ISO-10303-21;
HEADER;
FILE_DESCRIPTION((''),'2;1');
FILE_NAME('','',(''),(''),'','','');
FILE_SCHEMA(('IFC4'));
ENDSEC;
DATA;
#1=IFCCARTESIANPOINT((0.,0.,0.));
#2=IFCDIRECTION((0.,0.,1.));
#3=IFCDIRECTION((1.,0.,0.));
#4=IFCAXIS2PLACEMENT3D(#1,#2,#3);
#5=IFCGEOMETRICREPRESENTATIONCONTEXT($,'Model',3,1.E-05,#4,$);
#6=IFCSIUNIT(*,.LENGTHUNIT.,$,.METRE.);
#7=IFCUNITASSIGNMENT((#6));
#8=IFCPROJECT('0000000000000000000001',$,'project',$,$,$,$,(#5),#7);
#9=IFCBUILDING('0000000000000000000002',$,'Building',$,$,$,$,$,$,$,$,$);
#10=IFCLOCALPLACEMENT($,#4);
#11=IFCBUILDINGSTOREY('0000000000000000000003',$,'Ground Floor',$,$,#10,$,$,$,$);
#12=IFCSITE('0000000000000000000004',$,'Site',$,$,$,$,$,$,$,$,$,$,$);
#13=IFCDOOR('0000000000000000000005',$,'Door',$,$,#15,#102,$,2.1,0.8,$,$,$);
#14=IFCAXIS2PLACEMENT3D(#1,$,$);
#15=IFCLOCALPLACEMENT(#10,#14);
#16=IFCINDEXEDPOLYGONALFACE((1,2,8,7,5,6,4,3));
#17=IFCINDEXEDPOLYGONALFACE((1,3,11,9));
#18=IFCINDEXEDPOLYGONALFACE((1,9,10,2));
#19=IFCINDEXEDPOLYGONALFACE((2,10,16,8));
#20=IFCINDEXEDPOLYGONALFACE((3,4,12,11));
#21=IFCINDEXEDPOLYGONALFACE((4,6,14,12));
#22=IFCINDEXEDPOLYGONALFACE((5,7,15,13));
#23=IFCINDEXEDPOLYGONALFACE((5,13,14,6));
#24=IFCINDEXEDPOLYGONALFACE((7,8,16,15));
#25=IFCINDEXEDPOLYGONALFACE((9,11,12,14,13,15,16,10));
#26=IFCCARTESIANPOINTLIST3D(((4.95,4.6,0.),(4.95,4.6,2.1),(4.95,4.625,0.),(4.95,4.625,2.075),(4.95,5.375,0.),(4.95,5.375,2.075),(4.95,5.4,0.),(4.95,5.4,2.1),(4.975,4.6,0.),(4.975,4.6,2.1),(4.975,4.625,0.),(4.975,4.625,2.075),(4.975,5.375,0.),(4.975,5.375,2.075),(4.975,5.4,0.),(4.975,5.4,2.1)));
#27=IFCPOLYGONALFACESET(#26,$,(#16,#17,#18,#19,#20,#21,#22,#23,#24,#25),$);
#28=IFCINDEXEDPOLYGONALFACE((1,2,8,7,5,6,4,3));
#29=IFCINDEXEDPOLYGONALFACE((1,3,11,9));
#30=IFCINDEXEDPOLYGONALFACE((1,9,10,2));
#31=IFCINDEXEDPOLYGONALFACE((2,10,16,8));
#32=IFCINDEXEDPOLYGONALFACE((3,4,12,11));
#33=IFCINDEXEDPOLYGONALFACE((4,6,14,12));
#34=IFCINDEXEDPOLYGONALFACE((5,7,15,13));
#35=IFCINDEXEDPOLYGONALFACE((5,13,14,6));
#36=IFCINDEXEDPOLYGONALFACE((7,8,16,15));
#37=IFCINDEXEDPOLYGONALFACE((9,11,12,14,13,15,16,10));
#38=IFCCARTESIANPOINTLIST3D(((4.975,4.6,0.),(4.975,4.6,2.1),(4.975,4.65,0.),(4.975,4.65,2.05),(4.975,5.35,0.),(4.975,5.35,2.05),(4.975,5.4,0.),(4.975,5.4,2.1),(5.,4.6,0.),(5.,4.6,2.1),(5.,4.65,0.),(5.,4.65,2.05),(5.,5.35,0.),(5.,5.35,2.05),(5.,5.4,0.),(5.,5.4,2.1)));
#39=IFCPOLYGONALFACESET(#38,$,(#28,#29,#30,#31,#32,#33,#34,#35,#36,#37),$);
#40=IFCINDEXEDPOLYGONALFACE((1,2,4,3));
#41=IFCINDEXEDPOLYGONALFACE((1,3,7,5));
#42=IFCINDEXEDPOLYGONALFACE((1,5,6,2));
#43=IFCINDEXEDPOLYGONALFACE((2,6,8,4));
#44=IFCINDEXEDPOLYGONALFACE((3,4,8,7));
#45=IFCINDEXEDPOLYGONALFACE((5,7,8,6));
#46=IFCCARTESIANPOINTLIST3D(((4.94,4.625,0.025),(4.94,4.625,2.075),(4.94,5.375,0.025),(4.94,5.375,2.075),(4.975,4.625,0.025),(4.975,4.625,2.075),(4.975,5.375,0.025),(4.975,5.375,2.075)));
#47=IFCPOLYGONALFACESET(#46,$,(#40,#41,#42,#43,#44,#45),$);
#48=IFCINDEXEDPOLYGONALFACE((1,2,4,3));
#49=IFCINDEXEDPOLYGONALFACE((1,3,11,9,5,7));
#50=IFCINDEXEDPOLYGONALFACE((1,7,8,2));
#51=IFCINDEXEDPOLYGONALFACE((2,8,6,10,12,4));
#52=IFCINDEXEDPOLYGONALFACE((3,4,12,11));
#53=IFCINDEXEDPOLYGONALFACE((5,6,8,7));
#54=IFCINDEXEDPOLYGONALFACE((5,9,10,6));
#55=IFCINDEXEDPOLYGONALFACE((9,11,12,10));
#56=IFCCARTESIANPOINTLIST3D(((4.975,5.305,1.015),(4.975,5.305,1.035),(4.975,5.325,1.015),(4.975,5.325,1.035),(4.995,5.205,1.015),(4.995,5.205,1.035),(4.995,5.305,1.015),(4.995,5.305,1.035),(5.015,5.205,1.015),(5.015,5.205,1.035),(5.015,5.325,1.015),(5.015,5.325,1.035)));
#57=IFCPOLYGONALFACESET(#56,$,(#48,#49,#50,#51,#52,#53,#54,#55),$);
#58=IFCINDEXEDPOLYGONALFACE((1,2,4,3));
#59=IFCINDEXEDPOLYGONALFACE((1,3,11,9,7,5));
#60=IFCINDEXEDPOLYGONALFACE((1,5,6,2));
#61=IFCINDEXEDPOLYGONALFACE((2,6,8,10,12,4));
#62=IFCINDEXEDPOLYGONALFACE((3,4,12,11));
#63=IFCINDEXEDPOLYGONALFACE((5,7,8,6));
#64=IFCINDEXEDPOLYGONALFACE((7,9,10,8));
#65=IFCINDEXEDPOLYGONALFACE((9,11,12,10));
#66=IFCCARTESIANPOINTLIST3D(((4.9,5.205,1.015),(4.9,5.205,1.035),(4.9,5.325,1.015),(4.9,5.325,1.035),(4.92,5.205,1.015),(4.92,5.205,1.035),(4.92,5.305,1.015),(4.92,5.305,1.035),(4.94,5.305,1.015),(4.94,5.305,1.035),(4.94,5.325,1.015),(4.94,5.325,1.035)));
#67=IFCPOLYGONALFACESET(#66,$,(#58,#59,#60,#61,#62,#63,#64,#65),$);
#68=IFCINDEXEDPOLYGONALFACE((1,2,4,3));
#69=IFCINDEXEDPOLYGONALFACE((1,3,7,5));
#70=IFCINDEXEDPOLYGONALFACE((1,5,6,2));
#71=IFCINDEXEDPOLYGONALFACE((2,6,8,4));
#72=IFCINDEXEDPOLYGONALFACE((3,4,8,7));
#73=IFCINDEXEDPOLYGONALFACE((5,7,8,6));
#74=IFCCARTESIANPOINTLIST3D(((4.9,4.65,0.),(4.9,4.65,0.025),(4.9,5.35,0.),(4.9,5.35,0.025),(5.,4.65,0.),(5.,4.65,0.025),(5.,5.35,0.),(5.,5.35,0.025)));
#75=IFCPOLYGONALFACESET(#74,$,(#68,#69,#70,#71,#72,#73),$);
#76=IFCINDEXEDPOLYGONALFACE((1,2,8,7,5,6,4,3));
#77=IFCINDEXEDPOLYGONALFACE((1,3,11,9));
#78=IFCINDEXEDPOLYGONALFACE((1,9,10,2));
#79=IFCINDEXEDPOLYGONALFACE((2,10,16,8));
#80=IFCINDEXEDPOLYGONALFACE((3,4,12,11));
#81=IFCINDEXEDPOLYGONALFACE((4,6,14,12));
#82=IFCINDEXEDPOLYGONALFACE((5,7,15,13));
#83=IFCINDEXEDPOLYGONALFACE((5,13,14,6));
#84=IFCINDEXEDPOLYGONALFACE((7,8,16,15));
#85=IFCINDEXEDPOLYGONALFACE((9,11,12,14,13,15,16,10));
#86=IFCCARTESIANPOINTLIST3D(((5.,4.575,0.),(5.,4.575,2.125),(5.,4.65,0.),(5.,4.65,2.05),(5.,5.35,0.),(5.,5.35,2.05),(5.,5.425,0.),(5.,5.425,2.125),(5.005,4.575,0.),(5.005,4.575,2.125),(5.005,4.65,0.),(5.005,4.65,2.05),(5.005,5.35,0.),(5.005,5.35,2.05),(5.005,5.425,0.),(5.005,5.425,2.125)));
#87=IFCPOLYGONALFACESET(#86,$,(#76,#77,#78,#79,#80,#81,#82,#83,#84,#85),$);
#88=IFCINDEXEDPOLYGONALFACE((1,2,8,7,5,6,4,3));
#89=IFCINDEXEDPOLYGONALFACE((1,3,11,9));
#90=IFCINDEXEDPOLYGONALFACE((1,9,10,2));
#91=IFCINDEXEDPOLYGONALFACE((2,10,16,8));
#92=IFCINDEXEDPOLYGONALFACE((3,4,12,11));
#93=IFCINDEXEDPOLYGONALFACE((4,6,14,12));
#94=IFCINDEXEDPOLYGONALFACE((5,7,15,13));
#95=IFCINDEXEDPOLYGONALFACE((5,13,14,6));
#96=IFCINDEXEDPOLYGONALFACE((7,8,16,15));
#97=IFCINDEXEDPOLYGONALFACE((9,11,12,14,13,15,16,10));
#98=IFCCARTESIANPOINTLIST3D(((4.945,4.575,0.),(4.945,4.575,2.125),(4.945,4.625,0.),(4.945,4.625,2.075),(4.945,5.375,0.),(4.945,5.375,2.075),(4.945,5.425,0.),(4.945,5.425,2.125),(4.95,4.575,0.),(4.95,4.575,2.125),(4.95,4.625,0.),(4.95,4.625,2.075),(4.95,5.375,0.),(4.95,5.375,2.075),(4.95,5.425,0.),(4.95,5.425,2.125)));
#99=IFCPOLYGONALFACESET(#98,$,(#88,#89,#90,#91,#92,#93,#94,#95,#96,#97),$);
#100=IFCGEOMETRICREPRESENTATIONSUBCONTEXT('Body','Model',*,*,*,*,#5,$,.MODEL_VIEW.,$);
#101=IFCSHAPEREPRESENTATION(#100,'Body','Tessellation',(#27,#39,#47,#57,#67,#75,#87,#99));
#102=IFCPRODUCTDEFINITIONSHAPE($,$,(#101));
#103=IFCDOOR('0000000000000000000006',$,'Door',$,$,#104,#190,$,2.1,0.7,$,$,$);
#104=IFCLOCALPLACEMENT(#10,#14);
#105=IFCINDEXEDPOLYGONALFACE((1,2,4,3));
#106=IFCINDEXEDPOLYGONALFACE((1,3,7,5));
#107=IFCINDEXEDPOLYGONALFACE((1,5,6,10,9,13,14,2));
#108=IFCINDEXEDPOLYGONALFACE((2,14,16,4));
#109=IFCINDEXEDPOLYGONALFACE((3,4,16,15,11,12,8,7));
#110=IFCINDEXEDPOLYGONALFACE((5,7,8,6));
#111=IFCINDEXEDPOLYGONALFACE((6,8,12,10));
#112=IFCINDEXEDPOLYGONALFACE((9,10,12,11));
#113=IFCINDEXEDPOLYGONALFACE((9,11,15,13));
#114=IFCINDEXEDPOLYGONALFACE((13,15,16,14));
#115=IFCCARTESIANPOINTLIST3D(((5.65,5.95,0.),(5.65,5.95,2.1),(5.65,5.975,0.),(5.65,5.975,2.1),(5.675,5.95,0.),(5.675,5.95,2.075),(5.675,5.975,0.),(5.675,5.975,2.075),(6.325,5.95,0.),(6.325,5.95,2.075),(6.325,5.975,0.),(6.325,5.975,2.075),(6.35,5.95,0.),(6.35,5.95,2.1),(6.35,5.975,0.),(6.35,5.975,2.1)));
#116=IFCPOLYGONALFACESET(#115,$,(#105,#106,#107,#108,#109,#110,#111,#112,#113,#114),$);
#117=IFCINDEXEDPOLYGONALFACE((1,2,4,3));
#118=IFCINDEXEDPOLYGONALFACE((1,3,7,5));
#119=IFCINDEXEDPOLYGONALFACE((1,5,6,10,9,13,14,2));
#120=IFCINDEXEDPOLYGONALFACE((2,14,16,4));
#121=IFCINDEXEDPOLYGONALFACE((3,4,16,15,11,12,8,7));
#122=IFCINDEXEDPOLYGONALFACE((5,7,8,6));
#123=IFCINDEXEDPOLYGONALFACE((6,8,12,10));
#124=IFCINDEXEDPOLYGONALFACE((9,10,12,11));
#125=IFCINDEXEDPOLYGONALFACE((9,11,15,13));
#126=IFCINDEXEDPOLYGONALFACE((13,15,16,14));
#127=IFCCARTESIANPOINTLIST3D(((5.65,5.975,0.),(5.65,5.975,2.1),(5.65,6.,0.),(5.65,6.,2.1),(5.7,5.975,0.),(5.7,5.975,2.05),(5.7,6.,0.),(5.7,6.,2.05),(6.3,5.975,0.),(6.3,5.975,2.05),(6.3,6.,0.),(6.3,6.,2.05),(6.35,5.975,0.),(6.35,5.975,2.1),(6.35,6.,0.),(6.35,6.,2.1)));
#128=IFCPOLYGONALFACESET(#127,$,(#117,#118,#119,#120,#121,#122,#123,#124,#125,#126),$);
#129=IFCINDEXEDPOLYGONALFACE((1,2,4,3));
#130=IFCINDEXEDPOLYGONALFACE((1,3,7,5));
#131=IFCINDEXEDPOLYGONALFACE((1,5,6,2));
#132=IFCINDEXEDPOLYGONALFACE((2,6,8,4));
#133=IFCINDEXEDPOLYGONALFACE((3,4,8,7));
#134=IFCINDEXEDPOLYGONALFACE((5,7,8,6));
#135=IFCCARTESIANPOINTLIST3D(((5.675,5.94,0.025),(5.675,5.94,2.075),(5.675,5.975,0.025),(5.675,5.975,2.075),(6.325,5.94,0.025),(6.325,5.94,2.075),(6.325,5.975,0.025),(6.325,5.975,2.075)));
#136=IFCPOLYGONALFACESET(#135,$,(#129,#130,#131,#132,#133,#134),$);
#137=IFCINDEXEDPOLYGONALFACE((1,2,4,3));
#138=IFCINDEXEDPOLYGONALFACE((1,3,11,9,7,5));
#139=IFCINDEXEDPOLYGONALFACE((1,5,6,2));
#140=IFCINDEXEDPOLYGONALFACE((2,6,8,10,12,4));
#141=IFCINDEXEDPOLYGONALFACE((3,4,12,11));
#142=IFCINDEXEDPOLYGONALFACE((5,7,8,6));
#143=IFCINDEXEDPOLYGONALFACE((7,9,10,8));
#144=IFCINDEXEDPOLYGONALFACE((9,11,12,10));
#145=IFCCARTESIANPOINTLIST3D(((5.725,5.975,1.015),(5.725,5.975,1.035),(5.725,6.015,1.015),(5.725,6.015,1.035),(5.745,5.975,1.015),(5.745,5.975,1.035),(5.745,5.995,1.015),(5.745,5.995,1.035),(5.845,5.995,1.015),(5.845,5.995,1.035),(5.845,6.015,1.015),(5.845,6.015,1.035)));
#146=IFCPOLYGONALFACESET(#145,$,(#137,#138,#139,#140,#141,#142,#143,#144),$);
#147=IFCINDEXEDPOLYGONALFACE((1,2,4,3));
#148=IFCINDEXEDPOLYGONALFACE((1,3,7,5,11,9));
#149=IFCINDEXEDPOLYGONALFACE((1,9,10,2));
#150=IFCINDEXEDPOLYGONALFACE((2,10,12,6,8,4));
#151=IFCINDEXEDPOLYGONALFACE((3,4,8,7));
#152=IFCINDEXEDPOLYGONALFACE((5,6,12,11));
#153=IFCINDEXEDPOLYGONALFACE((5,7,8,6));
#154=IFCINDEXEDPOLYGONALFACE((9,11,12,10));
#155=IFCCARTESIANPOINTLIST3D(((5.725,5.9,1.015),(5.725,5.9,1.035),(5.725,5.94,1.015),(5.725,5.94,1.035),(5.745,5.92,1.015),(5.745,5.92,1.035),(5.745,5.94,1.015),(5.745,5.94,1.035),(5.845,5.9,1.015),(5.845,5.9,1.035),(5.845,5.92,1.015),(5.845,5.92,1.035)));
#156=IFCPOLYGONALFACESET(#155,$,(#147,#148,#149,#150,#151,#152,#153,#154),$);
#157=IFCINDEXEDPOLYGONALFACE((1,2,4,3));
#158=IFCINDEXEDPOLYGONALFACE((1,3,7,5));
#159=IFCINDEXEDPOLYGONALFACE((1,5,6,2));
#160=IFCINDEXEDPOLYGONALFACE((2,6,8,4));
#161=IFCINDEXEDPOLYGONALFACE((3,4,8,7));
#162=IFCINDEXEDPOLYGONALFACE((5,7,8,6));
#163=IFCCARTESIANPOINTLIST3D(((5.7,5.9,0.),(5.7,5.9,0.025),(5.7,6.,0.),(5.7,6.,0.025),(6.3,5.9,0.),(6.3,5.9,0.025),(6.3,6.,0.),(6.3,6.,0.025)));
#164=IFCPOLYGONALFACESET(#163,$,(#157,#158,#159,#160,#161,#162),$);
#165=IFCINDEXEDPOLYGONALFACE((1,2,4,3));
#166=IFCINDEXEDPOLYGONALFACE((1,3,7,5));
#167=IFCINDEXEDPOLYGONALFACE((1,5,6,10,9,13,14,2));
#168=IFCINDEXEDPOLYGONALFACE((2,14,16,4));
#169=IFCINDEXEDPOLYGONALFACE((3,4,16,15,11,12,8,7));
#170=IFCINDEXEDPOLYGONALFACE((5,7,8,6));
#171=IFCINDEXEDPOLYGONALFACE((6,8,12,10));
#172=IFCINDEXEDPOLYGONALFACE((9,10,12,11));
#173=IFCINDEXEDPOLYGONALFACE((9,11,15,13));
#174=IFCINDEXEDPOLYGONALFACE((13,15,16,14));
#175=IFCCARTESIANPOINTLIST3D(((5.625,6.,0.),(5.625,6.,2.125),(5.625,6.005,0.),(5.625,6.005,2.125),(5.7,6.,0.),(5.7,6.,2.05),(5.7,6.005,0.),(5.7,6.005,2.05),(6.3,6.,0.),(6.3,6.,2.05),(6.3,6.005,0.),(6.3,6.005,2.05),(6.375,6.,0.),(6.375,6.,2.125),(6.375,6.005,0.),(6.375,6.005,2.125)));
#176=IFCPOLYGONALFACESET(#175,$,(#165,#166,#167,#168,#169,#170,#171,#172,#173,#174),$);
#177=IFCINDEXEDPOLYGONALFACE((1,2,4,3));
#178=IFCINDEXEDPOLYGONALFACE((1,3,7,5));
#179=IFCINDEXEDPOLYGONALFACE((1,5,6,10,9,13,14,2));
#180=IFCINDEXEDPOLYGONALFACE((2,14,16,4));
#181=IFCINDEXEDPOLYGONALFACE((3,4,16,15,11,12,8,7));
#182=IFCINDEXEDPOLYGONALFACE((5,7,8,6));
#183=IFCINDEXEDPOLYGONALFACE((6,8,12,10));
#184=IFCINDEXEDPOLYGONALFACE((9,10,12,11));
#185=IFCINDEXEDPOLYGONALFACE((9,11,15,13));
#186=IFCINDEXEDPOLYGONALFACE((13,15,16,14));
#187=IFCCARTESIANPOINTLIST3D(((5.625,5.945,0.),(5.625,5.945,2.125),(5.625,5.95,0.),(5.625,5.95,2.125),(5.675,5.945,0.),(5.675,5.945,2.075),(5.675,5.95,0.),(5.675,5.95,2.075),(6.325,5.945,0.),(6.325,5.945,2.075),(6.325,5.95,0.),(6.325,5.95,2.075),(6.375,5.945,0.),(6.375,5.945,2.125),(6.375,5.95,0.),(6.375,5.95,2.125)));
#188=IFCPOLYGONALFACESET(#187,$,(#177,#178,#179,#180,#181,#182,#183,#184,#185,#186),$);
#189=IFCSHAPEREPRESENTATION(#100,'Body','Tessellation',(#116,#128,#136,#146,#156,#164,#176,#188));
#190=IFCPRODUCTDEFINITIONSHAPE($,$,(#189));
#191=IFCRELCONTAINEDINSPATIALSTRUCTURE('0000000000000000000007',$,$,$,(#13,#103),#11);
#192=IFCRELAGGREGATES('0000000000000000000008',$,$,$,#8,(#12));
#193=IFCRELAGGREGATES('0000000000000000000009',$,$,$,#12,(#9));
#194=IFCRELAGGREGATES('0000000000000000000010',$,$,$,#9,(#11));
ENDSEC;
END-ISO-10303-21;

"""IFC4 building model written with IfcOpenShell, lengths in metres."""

from ifc_helpers import new_model, si_unit, frame, origin_with_axes, place, context, subcontext, project, spatial, line, indexed_curve, outline, extrude, element, save


model = new_model("IFC4")

# Units and contexts
model_context = context("Model", 3, precision=1e-05, world=origin_with_axes())
body_context = subcontext(model_context, "Body", "Model", "MODEL_VIEW")
ifc_project = project(units=[si_unit("LENGTHUNIT", "METRE")], contexts=[model_context])

# Site, building, storey
site = spatial("IfcSite", under=ifc_project, Name="Site")
building = spatial("IfcBuilding", under=site, Name="Building")
storey_placement = place(None, origin_with_axes())
storey = spatial("IfcBuildingStorey", under=building, at=storey_placement, Name="Ground Floor")

# Doors
door_1_placement = place(storey_placement, frame((5.0, 4.6, 0.0), z_axis=(0.0, 0.0, 1.0), x_axis=(0.0, 1.0, 0.0)))
element("IfcDoor", 1, at=door_1_placement, inside=storey, Name="Door", OverallHeight=2.1, OverallWidth=0.8, context=body_context, shape_type="SweptSolid", body=[
    extrude(outline(indexed_curve([(0.0, 0.0), (0.0, 2.1), (0.8, 2.1), (0.8, 0.0), (0.775, 0.0), (0.775, 2.075), (0.025, 2.075), (0.025, 0.0)], segments=[line(1, 2, 3, 4, 5, 6, 7, 8, 1)])), frame((0.0, 0.025, 0.0), z_axis=(0.0, -1.0, 0.0), x_axis=(1.0, 0.0, 0.0)), (0.0, 0.0, -1.0), 0.025),
    extrude(outline(indexed_curve([(0.0, 0.0), (0.0, 2.1), (0.8, 2.1), (0.8, 0.0), (0.75, 0.0), (0.75, 2.05), (0.05, 2.05), (0.05, 0.0)], segments=[line(1, 2, 3, 4, 5, 6, 7, 8, 1)])), frame((0.0, 0.0, 0.0), z_axis=(0.0, -1.0, 0.0), x_axis=(1.0, 0.0, 0.0)), (0.0, 0.0, -1.0), 0.025),
    extrude(outline(indexed_curve([(0.0, 0.0), (0.75, 0.0), (0.75, 0.035), (0.0, 0.035)], segments=[line(1, 2, 3, 4, 1)])), frame((0.025, 0.025, 0.025), z_axis=(0.0, 0.0, 1.0), x_axis=(1.0, 0.0, 0.0)), (0.0, 0.0, 1.0), 2.05),
    extrude(outline(indexed_curve([(0.0, 0.0), (0.0, -0.04), (-0.12, -0.04), (-0.12, -0.02), (-0.02, -0.02), (-0.02, 0.0)], segments=[line(1, 2, 3, 4, 5, 6, 1)])), frame((0.725, 0.025, 1.015), z_axis=(0.0, 0.0, 1.0), x_axis=(1.0, 0.0, 0.0)), (0.0, 0.0, 1.0), 0.02),
    extrude(outline(indexed_curve([(0.0, 0.0), (0.0, 0.04), (-0.12, 0.04), (-0.12, 0.02), (-0.02, 0.02), (-0.02, 0.0)], segments=[line(1, 2, 3, 4, 5, 6, 1)])), frame((0.725, 0.06, 1.015), z_axis=(0.0, 0.0, 1.0), x_axis=(1.0, 0.0, 0.0)), (0.0, 0.0, 1.0), 0.02),
    extrude(outline(indexed_curve([(0.0, 0.0), (0.7, 0.0), (0.7, 0.1), (0.0, 0.1)], segments=[line(1, 2, 3, 4, 1)])), frame((0.05, 0.0, 0.0), z_axis=(0.0, 0.0, 1.0), x_axis=(1.0, 0.0, 0.0)), (0.0, 0.0, 1.0), 0.025),
    extrude(outline(indexed_curve([(0.0, 0.0), (0.0, 2.125), (0.85, 2.125), (0.85, 0.0), (0.775, 0.0), (0.775, 2.05), (0.075, 2.05), (0.075, 0.0)], segments=[line(1, 2, 3, 4, 5, 6, 7, 8, 1)])), frame((-0.025, -0.005, 0.0), z_axis=(0.0, -1.0, 0.0), x_axis=(1.0, 0.0, 0.0)), (0.0, 0.0, -1.0), 0.005),
    extrude(outline(indexed_curve([(0.0, 0.0), (0.0, 2.125), (0.85, 2.125), (0.85, 0.0), (0.8, 0.0), (0.8, 2.075), (0.05, 2.075), (0.05, 0.0)], segments=[line(1, 2, 3, 4, 5, 6, 7, 8, 1)])), frame((-0.025, 0.05, 0.0), z_axis=(0.0, -1.0, 0.0), x_axis=(1.0, 0.0, 0.0)), (0.0, 0.0, -1.0), 0.005),
])
door_2_placement = place(storey_placement, frame((6.35, 6.0, 0.0), z_axis=(0.0, 0.0, 1.0), x_axis=(-1.0, 0.0, 0.0)))
element("IfcDoor", 2, at=door_2_placement, inside=storey, Name="Door", OverallHeight=2.1, OverallWidth=0.7, context=body_context, shape_type="SweptSolid", body=[
    extrude(outline(indexed_curve([(0.0, 0.0), (0.0, 2.1), (0.7, 2.1), (0.7, 0.0), (0.675, 0.0), (0.675, 2.075), (0.025, 2.075), (0.025, 0.0)], segments=[line(1, 2, 3, 4, 5, 6, 7, 8, 1)])), frame((0.0, 0.025, 0.0), z_axis=(0.0, -1.0, 0.0), x_axis=(1.0, 0.0, 0.0)), (0.0, 0.0, -1.0), 0.025),
    extrude(outline(indexed_curve([(0.0, 0.0), (0.0, 2.1), (0.7, 2.1), (0.7, 0.0), (0.65, 0.0), (0.65, 2.05), (0.05, 2.05), (0.05, 0.0)], segments=[line(1, 2, 3, 4, 5, 6, 7, 8, 1)])), frame((0.0, 0.0, 0.0), z_axis=(0.0, -1.0, 0.0), x_axis=(1.0, 0.0, 0.0)), (0.0, 0.0, -1.0), 0.025),
    extrude(outline(indexed_curve([(0.0, 0.0), (0.65, 0.0), (0.65, 0.035), (0.0, 0.035)], segments=[line(1, 2, 3, 4, 1)])), frame((0.025, 0.025, 0.025), z_axis=(0.0, 0.0, 1.0), x_axis=(1.0, 0.0, 0.0)), (0.0, 0.0, 1.0), 2.05),
    extrude(outline(indexed_curve([(0.0, 0.0), (0.0, -0.04), (-0.12, -0.04), (-0.12, -0.02), (-0.02, -0.02), (-0.02, 0.0)], segments=[line(1, 2, 3, 4, 5, 6, 1)])), frame((0.625, 0.025, 1.015), z_axis=(0.0, 0.0, 1.0), x_axis=(1.0, 0.0, 0.0)), (0.0, 0.0, 1.0), 0.02),
    extrude(outline(indexed_curve([(0.0, 0.0), (0.0, 0.04), (-0.12, 0.04), (-0.12, 0.02), (-0.02, 0.02), (-0.02, 0.0)], segments=[line(1, 2, 3, 4, 5, 6, 1)])), frame((0.625, 0.06, 1.015), z_axis=(0.0, 0.0, 1.0), x_axis=(1.0, 0.0, 0.0)), (0.0, 0.0, 1.0), 0.02),
    extrude(outline(indexed_curve([(0.0, 0.0), (0.6, 0.0), (0.6, 0.1), (0.0, 0.1)], segments=[line(1, 2, 3, 4, 1)])), frame((0.05, 0.0, 0.0), z_axis=(0.0, 0.0, 1.0), x_axis=(1.0, 0.0, 0.0)), (0.0, 0.0, 1.0), 0.025),
    extrude(outline(indexed_curve([(0.0, 0.0), (0.0, 2.125), (0.75, 2.125), (0.75, 0.0), (0.675, 0.0), (0.675, 2.05), (0.075, 2.05), (0.075, 0.0)], segments=[line(1, 2, 3, 4, 5, 6, 7, 8, 1)])), frame((-0.025, -0.005, 0.0), z_axis=(0.0, -1.0, 0.0), x_axis=(1.0, 0.0, 0.0)), (0.0, 0.0, -1.0), 0.005),
    extrude(outline(indexed_curve([(0.0, 0.0), (0.0, 2.125), (0.75, 2.125), (0.75, 0.0), (0.7, 0.0), (0.7, 2.075), (0.05, 2.075), (0.05, 0.0)], segments=[line(1, 2, 3, 4, 5, 6, 7, 8, 1)])), frame((-0.025, 0.05, 0.0), z_axis=(0.0, -1.0, 0.0), x_axis=(1.0, 0.0, 0.0)), (0.0, 0.0, -1.0), 0.005),
])

save(model, "model.ifc")
